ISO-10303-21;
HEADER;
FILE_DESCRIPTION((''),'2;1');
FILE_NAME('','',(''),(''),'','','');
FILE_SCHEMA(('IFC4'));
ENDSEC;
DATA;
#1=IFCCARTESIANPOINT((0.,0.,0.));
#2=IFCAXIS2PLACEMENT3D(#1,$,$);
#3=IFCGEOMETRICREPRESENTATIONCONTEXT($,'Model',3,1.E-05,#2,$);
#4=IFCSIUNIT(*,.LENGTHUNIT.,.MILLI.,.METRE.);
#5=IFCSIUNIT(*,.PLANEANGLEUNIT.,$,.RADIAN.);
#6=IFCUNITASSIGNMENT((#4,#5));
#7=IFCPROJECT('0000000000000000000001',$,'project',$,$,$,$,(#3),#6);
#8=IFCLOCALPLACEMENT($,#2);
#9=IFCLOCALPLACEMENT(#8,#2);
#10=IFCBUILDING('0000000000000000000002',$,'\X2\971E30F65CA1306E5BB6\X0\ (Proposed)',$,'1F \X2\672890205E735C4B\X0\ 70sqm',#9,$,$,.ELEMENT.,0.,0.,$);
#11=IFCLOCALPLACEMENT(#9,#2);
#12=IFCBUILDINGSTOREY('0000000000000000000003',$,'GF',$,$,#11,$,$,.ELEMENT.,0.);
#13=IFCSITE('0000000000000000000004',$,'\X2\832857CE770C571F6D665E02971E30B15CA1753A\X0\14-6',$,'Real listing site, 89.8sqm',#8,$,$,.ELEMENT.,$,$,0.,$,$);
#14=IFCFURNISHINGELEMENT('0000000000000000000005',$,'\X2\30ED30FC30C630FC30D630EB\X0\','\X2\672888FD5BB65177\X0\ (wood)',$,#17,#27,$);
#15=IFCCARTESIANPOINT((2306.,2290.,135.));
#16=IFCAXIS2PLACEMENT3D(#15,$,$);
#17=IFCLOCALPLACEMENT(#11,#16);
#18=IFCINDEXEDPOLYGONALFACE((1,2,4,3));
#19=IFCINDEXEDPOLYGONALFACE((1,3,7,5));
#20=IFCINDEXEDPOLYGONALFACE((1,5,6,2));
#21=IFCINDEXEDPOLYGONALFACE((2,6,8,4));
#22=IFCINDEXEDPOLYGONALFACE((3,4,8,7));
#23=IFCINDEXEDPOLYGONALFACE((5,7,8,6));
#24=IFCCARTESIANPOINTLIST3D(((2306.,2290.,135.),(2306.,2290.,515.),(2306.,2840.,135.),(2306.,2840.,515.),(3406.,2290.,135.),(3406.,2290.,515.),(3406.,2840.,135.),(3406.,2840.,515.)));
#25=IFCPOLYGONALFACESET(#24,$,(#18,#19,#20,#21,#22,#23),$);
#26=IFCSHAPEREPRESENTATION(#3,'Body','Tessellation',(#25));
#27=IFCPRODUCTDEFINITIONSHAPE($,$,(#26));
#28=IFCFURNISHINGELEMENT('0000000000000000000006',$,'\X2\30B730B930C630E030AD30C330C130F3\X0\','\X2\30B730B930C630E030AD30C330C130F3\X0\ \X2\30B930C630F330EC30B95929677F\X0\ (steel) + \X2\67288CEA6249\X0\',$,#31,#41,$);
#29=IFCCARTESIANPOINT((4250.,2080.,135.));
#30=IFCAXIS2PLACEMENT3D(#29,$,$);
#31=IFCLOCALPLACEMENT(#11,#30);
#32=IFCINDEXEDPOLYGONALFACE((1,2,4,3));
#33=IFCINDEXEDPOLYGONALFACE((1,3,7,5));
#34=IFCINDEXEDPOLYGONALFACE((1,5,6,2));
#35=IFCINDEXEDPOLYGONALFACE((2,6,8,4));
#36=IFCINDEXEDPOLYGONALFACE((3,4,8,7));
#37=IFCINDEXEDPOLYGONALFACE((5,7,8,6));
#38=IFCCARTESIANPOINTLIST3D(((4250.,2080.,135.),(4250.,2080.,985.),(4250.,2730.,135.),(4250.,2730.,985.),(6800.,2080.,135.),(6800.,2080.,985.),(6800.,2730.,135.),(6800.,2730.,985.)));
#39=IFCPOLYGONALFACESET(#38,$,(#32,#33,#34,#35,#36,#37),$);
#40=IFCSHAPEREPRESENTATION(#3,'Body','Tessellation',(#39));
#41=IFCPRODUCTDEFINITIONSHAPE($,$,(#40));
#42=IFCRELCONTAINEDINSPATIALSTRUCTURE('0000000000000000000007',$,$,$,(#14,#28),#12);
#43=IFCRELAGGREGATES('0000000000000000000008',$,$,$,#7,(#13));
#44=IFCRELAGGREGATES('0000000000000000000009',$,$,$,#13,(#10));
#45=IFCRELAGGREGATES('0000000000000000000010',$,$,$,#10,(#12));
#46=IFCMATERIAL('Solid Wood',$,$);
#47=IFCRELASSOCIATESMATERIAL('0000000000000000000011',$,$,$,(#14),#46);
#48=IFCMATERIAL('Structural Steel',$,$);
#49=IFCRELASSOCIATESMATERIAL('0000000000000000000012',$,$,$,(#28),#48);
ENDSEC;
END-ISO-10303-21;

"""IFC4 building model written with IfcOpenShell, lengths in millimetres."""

from ifc_helpers import new_model, si_unit, frame, frame_2d, origin, place, context, project, spatial, rectangle, extrude, material, element, save


model = new_model("IFC4")

# Units and contexts
model_context = context("Model", 3, precision=1e-05, world=origin())
ifc_project = project(units=[si_unit("LENGTHUNIT", "METRE", prefix="MILLI"), si_unit("PLANEANGLEUNIT", "RADIAN")], contexts=[model_context])

# Site, building, storey
site_placement = place(None, origin())
site = spatial("IfcSite", under=ifc_project, at=site_placement, Name="茨城県土浦市霞ケ岡町14-6", ObjectType="Real listing site, 89.8sqm", CompositionType="ELEMENT", RefElevation=0.0)
building_placement = place(site_placement, origin())
building = spatial("IfcBuilding", under=site, at=building_placement, Name="霞ヶ岡の家 (Proposed)", ObjectType="1F 木造平屋 70sqm", CompositionType="ELEMENT", ElevationOfRefHeight=0.0, ElevationOfTerrain=0.0)
storey_placement = place(building_placement, origin())
storey = spatial("IfcBuildingStorey", under=building, at=storey_placement, Name="GF", CompositionType="ELEMENT", Elevation=0.0)

# Shared definitions
ifc_material_1 = material(Name="Solid Wood")

# Furnishing elements
furnishing_1_placement = place(storey_placement, frame((2306.0, 2290.0, 135.0)))
element("IfcFurnishingElement", 1, at=furnishing_1_placement, inside=storey, material=ifc_material_1, Name="ローテーブル", Description="木製家具 (wood)", context=model_context, shape_type="SweptSolid", body=[
    extrude(rectangle(XDim=1100.0, YDim=550.0, at=frame_2d((550.0, 275.0))), frame((2306.0, 2290.0, 135.0)), (0.0, 0.0, 1.0), 380.0),
])
ifc_material_2 = material(Name="Structural Steel")
furnishing_2_placement = place(storey_placement, frame((4250.0, 2080.0, 135.0)))
element("IfcFurnishingElement", 2, at=furnishing_2_placement, inside=storey, material=ifc_material_2, Name="システムキッチン", Description="システムキッチン ステンレス天板 (steel) + 木質扉", context=model_context, shape_type="SweptSolid", body=[
    extrude(rectangle(XDim=2550.0, YDim=650.0, at=frame_2d((1275.0, 325.0))), frame((4250.0, 2080.0, 135.0)), (0.0, 0.0, 1.0), 850.0),
])

save(model, "model.ifc")
